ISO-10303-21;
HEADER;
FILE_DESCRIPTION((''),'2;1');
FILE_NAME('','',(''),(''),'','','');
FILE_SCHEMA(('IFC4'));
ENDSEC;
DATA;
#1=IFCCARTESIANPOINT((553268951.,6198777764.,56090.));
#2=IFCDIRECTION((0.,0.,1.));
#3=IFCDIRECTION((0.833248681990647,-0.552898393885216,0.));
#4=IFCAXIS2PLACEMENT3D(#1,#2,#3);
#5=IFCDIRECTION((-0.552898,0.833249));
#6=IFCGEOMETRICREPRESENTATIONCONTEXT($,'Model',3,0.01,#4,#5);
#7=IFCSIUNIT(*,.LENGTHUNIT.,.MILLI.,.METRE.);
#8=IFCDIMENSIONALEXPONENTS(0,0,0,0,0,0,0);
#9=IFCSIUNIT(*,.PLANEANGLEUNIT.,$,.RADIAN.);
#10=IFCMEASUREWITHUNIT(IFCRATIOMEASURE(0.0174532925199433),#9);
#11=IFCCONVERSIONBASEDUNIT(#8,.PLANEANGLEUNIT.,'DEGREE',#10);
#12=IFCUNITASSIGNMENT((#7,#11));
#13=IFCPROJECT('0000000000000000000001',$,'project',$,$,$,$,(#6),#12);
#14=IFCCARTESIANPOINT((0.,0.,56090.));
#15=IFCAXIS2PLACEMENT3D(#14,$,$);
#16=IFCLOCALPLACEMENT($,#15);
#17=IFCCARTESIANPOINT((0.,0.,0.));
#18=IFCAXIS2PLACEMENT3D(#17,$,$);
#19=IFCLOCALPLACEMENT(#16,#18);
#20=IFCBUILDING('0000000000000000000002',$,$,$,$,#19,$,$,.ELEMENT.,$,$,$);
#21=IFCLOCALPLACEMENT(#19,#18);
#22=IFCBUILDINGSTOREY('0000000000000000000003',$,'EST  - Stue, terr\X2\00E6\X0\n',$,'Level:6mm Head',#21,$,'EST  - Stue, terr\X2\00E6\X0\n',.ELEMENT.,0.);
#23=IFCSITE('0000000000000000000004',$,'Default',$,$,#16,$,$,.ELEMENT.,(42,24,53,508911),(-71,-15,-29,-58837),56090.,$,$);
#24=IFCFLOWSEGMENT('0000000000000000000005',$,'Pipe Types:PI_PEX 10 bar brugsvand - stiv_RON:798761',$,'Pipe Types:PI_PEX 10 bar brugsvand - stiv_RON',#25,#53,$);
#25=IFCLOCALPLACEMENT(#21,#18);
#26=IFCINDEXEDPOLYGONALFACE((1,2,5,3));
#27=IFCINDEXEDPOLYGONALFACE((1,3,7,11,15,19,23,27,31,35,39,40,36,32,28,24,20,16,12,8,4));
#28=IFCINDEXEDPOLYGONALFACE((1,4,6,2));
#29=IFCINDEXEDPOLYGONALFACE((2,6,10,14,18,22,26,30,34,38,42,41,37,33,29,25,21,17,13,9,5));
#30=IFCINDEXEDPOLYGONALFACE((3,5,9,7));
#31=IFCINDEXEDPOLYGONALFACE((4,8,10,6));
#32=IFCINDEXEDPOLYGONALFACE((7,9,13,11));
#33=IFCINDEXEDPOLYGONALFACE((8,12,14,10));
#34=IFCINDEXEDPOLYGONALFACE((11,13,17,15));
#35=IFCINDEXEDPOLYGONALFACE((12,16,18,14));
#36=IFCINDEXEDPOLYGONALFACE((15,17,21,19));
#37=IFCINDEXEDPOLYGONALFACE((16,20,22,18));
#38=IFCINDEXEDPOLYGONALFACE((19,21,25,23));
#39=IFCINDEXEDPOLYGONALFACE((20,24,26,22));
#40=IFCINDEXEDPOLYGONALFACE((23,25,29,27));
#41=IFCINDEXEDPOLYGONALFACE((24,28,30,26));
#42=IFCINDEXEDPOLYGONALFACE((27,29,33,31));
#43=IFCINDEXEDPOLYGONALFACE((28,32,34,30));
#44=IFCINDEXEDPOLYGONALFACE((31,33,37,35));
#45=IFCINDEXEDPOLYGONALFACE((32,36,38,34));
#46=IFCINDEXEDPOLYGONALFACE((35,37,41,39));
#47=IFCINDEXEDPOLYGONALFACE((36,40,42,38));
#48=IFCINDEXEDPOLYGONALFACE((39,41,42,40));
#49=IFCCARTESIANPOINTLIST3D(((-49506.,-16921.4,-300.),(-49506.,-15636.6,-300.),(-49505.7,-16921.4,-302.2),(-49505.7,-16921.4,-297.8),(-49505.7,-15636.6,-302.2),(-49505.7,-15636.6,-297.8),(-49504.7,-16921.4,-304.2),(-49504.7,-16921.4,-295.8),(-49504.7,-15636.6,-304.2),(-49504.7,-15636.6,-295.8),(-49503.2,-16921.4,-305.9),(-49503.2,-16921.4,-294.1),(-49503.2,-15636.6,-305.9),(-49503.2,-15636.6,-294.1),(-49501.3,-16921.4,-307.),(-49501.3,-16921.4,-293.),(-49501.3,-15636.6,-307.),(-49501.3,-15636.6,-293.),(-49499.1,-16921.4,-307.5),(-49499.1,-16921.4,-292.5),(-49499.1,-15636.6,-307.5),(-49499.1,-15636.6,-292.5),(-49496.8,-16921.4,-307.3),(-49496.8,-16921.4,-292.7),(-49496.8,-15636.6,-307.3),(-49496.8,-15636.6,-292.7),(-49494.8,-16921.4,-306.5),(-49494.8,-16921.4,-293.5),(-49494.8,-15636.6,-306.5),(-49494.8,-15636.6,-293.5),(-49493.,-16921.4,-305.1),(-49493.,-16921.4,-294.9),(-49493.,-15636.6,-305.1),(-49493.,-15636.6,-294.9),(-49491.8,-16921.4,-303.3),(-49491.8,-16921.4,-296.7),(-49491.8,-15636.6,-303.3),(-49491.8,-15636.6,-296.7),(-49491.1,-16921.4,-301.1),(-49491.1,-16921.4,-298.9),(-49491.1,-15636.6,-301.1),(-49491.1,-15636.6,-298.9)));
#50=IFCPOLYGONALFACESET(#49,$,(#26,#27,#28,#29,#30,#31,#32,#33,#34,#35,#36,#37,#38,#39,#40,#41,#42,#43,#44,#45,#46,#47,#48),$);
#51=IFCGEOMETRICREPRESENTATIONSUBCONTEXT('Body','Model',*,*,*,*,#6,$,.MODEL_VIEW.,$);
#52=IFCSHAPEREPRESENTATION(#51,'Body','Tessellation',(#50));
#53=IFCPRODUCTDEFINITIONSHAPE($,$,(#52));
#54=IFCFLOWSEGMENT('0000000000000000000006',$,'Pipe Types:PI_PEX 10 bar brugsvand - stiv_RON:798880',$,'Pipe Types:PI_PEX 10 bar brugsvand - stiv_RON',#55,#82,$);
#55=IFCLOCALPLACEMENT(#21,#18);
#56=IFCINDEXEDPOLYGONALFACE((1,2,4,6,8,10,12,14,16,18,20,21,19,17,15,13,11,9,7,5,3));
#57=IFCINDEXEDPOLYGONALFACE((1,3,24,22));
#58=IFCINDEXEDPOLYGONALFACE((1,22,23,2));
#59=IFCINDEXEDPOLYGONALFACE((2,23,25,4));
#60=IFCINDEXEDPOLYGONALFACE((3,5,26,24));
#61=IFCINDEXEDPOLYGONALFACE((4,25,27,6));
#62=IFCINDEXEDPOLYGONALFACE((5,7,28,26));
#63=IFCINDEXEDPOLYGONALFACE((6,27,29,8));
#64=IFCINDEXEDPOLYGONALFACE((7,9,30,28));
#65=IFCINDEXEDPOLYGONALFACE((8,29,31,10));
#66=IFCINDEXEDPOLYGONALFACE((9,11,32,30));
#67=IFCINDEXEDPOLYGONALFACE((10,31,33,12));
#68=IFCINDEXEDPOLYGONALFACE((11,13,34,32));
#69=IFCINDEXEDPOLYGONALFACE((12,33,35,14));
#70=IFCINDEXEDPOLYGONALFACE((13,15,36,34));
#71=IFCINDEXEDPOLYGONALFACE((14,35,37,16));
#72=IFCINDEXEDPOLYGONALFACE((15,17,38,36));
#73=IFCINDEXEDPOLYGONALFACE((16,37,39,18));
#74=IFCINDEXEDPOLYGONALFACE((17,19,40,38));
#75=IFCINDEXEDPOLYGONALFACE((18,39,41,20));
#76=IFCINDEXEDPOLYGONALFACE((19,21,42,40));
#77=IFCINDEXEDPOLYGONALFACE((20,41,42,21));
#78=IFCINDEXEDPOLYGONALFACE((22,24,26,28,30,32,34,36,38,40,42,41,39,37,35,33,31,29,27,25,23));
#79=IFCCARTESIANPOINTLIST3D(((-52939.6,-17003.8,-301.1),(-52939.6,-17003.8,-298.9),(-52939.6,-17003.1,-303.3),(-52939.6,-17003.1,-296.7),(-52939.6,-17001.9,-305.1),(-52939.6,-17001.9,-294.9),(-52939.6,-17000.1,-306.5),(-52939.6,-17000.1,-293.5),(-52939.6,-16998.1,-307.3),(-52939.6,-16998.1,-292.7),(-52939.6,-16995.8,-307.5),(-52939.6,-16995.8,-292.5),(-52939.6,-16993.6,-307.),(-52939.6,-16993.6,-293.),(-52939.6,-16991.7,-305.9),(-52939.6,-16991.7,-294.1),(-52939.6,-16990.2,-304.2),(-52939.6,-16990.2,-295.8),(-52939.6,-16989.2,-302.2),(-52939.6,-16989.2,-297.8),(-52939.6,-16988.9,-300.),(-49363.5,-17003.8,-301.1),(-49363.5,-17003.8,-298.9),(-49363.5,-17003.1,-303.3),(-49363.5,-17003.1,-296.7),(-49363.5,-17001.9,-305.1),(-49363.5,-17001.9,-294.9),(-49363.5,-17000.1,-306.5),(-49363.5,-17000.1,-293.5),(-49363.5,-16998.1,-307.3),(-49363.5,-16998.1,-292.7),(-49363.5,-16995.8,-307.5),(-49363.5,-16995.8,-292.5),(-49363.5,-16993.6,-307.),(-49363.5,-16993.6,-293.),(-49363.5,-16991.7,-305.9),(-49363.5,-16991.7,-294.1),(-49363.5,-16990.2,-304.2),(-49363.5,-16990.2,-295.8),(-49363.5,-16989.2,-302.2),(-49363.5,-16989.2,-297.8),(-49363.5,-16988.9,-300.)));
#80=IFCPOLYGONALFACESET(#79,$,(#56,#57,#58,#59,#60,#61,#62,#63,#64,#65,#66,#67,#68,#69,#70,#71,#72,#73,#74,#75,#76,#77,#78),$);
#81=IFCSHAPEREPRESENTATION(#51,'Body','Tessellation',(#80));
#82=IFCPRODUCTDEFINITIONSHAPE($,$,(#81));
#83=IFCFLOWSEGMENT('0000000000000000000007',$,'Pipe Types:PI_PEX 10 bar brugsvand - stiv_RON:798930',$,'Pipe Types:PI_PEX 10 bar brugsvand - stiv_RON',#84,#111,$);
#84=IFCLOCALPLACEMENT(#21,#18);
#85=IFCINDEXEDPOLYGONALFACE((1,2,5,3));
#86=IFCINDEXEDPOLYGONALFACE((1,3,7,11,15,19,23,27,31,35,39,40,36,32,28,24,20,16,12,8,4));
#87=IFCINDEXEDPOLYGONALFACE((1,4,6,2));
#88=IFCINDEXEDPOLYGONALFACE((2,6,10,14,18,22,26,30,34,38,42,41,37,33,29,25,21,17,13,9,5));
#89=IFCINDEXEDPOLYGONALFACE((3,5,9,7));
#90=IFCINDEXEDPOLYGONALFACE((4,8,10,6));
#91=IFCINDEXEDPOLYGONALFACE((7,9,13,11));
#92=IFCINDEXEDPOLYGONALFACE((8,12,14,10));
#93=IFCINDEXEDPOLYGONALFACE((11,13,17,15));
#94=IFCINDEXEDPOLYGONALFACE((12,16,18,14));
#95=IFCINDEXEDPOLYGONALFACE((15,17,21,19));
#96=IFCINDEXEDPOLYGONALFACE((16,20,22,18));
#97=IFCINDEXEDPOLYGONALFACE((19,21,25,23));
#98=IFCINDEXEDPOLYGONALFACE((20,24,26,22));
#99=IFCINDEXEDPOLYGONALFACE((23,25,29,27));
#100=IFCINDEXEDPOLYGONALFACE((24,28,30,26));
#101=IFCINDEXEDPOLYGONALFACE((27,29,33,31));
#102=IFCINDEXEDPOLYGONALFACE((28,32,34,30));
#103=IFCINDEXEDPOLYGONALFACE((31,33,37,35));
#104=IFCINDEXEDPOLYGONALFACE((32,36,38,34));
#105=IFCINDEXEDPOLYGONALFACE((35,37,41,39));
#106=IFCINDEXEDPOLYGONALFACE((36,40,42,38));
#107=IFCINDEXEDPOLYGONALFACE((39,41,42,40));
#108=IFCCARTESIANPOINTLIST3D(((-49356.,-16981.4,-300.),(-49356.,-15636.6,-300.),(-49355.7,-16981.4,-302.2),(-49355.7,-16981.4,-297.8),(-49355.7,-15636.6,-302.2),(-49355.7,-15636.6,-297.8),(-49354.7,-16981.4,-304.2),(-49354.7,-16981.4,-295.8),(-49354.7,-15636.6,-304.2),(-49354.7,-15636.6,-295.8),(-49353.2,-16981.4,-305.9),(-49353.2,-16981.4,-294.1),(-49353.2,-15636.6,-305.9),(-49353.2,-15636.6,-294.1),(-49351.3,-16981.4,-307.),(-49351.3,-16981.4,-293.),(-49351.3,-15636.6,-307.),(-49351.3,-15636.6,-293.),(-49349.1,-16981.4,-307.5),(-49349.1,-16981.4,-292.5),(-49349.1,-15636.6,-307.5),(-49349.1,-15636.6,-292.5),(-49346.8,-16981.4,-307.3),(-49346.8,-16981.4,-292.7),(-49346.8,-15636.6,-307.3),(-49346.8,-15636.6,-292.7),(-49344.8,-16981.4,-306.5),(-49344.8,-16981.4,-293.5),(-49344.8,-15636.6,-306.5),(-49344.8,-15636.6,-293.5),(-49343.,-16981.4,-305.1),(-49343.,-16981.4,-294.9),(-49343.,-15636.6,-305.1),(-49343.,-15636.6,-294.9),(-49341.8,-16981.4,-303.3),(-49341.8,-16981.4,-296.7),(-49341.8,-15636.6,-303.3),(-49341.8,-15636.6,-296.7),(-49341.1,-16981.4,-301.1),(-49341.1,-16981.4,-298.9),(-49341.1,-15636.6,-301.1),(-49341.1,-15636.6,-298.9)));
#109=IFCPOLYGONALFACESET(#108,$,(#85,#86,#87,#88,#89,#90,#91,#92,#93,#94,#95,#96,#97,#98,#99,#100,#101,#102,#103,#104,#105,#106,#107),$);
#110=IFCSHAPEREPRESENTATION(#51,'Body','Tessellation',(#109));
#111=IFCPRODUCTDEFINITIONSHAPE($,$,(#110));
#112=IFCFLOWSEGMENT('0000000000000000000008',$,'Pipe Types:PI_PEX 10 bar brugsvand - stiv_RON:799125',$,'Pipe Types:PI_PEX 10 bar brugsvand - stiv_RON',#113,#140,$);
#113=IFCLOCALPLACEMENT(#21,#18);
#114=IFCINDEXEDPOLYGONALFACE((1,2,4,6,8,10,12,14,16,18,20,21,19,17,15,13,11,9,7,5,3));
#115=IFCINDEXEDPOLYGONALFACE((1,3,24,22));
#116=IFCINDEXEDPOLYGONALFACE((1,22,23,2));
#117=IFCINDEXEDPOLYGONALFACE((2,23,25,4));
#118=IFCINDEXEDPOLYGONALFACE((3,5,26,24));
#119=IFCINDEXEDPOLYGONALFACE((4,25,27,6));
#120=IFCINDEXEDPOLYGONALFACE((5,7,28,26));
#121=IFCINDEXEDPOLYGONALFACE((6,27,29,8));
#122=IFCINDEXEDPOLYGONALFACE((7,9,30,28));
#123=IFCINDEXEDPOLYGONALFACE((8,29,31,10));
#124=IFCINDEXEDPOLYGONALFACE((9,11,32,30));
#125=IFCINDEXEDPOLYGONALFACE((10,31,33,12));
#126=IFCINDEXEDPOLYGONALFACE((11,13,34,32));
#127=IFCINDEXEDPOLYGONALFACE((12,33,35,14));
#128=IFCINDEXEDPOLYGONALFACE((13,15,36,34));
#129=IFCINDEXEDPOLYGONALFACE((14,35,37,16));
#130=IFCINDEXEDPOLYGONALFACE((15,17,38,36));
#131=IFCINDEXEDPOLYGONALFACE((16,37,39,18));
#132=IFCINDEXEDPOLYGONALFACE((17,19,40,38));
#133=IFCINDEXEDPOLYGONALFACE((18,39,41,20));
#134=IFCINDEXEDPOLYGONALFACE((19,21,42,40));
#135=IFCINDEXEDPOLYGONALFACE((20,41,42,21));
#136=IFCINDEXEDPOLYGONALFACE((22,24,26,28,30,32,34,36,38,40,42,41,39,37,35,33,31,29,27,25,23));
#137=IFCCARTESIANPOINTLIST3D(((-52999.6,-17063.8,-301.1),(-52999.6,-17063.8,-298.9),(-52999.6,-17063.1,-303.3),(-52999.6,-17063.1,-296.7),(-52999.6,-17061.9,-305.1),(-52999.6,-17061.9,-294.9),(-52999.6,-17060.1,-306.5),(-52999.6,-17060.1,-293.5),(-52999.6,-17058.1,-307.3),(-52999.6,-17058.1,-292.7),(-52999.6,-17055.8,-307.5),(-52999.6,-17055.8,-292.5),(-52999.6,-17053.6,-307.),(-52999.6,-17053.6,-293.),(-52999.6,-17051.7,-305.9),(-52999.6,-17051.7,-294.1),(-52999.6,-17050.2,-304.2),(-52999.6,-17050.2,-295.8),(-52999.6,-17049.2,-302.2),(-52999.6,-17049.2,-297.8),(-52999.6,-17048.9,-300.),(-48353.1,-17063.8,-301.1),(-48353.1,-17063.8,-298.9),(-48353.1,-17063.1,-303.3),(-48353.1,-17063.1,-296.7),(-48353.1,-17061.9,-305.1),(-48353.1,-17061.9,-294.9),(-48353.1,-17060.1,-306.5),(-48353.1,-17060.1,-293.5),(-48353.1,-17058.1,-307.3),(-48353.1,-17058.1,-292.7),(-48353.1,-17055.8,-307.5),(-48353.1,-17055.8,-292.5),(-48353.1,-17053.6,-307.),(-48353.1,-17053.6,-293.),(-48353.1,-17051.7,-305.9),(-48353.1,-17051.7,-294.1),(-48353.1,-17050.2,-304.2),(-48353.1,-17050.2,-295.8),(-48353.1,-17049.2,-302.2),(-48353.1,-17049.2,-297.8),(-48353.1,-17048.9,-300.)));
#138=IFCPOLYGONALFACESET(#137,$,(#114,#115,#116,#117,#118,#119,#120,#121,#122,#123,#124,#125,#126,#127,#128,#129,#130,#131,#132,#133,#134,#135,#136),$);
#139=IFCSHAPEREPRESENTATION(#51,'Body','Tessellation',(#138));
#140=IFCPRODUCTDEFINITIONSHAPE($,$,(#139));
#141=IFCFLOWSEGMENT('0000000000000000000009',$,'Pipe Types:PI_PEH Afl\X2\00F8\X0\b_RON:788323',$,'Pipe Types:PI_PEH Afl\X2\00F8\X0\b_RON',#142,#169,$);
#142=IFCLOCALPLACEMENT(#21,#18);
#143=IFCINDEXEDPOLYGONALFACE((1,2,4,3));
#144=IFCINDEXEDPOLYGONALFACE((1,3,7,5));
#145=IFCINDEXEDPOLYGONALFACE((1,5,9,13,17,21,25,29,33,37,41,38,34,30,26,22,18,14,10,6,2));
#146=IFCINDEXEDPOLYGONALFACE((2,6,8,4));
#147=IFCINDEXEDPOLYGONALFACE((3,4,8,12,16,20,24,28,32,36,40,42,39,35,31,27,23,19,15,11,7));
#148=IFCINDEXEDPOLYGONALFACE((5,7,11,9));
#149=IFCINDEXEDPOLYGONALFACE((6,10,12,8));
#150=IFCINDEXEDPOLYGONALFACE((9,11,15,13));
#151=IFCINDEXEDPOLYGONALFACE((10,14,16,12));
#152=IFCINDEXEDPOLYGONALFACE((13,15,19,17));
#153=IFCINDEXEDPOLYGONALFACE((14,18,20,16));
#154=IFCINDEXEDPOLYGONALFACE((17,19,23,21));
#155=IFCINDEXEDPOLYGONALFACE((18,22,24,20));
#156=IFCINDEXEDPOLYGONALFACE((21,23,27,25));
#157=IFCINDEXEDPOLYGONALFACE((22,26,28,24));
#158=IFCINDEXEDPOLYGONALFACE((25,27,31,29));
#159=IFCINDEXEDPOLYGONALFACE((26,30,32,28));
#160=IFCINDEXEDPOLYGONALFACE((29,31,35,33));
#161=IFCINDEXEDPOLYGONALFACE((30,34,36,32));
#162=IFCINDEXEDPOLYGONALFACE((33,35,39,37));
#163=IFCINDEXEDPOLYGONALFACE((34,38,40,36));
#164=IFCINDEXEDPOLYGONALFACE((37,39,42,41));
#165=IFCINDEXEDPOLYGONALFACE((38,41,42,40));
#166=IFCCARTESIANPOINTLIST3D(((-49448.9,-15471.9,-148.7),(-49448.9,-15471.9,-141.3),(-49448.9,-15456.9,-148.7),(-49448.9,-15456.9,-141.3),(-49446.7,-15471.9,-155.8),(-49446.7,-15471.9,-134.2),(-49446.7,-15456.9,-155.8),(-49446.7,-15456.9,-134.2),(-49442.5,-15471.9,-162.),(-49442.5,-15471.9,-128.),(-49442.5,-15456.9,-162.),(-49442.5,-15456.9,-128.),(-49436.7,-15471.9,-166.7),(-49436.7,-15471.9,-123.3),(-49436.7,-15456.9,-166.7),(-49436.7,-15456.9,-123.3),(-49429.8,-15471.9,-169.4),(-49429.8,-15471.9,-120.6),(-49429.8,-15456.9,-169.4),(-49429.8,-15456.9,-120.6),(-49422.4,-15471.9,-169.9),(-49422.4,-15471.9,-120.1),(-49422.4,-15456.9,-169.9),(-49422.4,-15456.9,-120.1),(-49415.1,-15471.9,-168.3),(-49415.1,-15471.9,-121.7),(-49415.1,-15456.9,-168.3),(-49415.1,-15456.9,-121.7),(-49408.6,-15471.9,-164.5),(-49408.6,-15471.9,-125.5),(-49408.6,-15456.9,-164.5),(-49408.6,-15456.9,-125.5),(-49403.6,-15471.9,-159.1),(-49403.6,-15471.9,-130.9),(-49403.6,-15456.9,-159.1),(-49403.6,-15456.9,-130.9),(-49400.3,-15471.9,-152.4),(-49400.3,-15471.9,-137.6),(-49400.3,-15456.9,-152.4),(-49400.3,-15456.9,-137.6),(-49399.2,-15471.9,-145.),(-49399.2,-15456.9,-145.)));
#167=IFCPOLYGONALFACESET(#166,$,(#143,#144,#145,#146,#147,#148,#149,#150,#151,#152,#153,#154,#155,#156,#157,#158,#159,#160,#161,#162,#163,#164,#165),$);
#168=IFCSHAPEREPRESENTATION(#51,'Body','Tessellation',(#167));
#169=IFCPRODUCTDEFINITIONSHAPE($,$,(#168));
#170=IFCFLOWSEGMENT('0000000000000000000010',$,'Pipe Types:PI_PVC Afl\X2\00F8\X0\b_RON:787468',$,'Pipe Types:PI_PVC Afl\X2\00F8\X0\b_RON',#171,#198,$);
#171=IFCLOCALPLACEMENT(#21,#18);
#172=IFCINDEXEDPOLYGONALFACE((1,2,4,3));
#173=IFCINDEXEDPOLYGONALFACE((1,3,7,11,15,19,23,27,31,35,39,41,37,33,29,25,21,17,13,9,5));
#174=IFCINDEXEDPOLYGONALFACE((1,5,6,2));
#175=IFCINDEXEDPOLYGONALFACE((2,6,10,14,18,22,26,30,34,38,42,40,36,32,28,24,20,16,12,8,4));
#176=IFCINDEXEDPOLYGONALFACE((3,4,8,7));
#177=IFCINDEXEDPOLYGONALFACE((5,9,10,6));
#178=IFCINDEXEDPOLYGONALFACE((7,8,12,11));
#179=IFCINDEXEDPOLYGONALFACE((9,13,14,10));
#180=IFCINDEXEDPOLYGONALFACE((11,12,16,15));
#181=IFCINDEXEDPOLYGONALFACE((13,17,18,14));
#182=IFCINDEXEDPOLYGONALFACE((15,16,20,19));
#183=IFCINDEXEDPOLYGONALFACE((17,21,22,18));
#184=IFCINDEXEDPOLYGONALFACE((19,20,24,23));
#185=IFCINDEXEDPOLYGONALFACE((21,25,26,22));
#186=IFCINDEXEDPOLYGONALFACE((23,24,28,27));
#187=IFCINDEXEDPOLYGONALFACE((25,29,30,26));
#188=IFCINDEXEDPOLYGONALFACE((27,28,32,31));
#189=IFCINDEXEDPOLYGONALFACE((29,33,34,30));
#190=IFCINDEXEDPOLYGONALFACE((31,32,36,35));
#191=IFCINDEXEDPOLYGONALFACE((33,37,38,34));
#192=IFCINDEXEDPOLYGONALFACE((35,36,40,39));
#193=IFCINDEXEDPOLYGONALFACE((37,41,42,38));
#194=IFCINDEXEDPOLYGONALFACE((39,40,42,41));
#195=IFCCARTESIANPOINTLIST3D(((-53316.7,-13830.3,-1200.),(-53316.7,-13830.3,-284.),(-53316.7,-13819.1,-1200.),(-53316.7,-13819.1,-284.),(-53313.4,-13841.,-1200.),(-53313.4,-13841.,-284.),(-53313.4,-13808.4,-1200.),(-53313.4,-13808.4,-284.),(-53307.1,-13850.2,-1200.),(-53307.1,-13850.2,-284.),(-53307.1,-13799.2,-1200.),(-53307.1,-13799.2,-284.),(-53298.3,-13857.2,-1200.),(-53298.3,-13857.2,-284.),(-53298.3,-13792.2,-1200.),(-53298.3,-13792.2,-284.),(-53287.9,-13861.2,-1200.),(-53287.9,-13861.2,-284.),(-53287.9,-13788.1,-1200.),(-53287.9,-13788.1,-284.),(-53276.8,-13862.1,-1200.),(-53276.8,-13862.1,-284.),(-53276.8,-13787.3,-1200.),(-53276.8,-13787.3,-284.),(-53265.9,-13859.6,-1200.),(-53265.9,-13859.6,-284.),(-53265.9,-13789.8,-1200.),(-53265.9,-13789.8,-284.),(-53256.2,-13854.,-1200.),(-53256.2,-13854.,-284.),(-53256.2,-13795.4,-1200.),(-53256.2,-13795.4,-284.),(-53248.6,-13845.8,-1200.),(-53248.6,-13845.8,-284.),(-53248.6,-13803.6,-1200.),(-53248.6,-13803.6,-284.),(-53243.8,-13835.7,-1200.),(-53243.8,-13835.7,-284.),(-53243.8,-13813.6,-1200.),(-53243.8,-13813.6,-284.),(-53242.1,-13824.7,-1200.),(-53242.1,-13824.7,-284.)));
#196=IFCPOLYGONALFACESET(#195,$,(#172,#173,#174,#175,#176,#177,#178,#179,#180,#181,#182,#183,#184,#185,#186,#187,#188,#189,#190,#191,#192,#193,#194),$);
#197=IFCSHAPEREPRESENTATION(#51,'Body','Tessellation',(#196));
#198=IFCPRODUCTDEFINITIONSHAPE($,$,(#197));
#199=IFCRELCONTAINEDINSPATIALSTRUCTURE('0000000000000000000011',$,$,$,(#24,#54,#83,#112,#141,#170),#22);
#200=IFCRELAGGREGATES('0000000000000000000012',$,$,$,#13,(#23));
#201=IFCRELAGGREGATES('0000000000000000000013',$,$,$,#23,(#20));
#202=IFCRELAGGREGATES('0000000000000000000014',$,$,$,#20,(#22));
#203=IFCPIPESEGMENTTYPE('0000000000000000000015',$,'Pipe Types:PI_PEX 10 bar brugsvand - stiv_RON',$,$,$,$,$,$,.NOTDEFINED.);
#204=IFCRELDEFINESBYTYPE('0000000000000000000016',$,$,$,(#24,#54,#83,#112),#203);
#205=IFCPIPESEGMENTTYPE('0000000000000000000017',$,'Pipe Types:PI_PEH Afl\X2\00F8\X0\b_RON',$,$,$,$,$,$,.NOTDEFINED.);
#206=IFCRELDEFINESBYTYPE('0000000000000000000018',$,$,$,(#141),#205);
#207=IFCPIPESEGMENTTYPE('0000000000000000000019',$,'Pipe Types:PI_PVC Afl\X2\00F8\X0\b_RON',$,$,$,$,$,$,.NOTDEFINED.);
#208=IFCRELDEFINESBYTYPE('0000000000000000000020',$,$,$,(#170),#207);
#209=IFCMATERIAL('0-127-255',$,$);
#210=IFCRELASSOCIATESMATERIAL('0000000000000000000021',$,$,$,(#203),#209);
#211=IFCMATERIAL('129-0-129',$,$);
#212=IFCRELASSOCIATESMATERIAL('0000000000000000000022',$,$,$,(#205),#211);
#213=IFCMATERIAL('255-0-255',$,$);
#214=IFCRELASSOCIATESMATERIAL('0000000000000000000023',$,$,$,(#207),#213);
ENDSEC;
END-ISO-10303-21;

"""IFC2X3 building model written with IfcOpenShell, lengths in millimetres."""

from ifc_helpers import new_model, entity, si_unit, converted_unit, direction, frame, frame_2d, origin, origin_2d_with_axis, place, context, subcontext, project, spatial, circle, extrude, material, type_object, element, save


model = new_model("IFC2X3")

# Units and contexts
model_context = context("Model", 3, precision=0.01, world=frame((553268951.0, 6198777764.0, 56090.0), z_axis=(0.0, 0.0, 1.0), x_axis=(0.833248681990647, -0.552898393885216, 0.0)), true_north=direction((-0.552898, 0.833249)))
body_context = subcontext(model_context, "Body", "Model", "MODEL_VIEW")
ifc_project = project(units=[si_unit("LENGTHUNIT", "METRE", prefix="MILLI"), converted_unit("PLANEANGLEUNIT", "DEGREE", entity("IfcRatioMeasure", 0.0174532925199433), si_unit("PLANEANGLEUNIT", "RADIAN"), dimensions=[0, 0, 0, 0, 0, 0, 0])], contexts=[model_context])

# Site, building, storey
site_placement = place(None, frame((0.0, 0.0, 56090.0)))
site = spatial("IfcSite", under=ifc_project, at=site_placement, Name="Default", CompositionType="ELEMENT", RefLatitude=(42, 24, 53, 508911), RefLongitude=(-71, -15, -29, -58837), RefElevation=56090.0)
building_placement = place(site_placement, origin())
building = spatial("IfcBuilding", under=site, at=building_placement, CompositionType="ELEMENT")
storey_placement = place(building_placement, frame((0.0, 0.0, 0.0)))
storey = spatial("IfcBuildingStorey", under=building, at=storey_placement, Name="EST  - Stue, terræn", ObjectType="Level:6mm Head", LongName="EST  - Stue, terræn", CompositionType="ELEMENT", Elevation=0.0)

# Flow segments
ifc_material_1 = material(Name="0-127-255")
pipe_segment_type_1 = type_object("IfcPipeSegmentType", Name="Pipe Types:PI_PEX 10 bar brugsvand - stiv_RON", PredefinedType="NOTDEFINED", material=ifc_material_1)
flow_segment_1_placement = place(storey_placement, origin())
element("IfcFlowSegment", 1, at=flow_segment_1_placement, inside=storey, type_object=pipe_segment_type_1, Name="Pipe Types:PI_PEX 10 bar brugsvand - stiv_RON:798761", ObjectType="Pipe Types:PI_PEX 10 bar brugsvand - stiv_RON", context=body_context, shape_type="SweptSolid", body=[
    extrude(circle(Radius=7.5, at=frame_2d((0.0, 0.0), x_axis=(1.0, 0.0))), frame((-49498.5, -16921.4, -300.0), z_axis=(0.0, 1.0, 0.0), x_axis=(-1.0, 0.0, 0.0)), (0.0, 0.0, 1.0), 1284.8),
])
flow_segment_2_placement = place(storey_placement, origin())
element("IfcFlowSegment", 2, at=flow_segment_2_placement, inside=storey, type_object=pipe_segment_type_1, Name="Pipe Types:PI_PEX 10 bar brugsvand - stiv_RON:798880", ObjectType="Pipe Types:PI_PEX 10 bar brugsvand - stiv_RON", context=body_context, shape_type="SweptSolid", body=[
    extrude(circle(Radius=7.5, at=frame_2d((0.0, 0.0), x_axis=(1.0, 0.0))), frame((-52939.6, -16996.4, -300.0), z_axis=(1.0, 0.0, 0.0), x_axis=(0.0, 1.0, 0.0)), (0.0, 0.0, 1.0), 3576.0),
])
flow_segment_3_placement = place(storey_placement, origin())
element("IfcFlowSegment", 3, at=flow_segment_3_placement, inside=storey, type_object=pipe_segment_type_1, Name="Pipe Types:PI_PEX 10 bar brugsvand - stiv_RON:798930", ObjectType="Pipe Types:PI_PEX 10 bar brugsvand - stiv_RON", context=body_context, shape_type="SweptSolid", body=[
    extrude(circle(Radius=7.5, at=origin_2d_with_axis()), frame((-49348.5, -16981.4, -300.0), z_axis=(0.0, 1.0, 0.0), x_axis=(-1.0, 0.0, 0.0)), (0.0, 0.0, 1.0), 1344.8),
])
flow_segment_4_placement = place(storey_placement, origin())
element("IfcFlowSegment", 4, at=flow_segment_4_placement, inside=storey, type_object=pipe_segment_type_1, Name="Pipe Types:PI_PEX 10 bar brugsvand - stiv_RON:799125", ObjectType="Pipe Types:PI_PEX 10 bar brugsvand - stiv_RON", context=body_context, shape_type="SweptSolid", body=[
    extrude(circle(Radius=7.5, at=frame_2d((0.0, 0.0), x_axis=(1.0, 0.0))), frame((-52999.6, -17056.4, -300.0), z_axis=(1.0, 0.0, 0.0), x_axis=(0.0, 1.0, 0.0)), (0.0, 0.0, 1.0), 4646.5),
])
ifc_material_2 = material(Name="129-0-129")
pipe_segment_type_2 = type_object("IfcPipeSegmentType", Name="Pipe Types:PI_PEH Afløb_RON", PredefinedType="NOTDEFINED", material=ifc_material_2)
flow_segment_5_placement = place(storey_placement, origin())
element("IfcFlowSegment", 5, at=flow_segment_5_placement, inside=storey, type_object=pipe_segment_type_2, Name="Pipe Types:PI_PEH Afløb_RON:788323", ObjectType="Pipe Types:PI_PEH Afløb_RON", context=body_context, shape_type="SweptSolid", body=[
    extrude(circle(Radius=25.0, at=frame_2d((0.0, 0.0), x_axis=(1.0, 0.0))), frame((-49424.2, -15471.9, -145.0), z_axis=(0.0, 1.0, 0.0), x_axis=(1.0, 0.0, 0.0)), (0.0, 0.0, 1.0), 15.0),
])
ifc_material_3 = material(Name="255-0-255")
pipe_segment_type_3 = type_object("IfcPipeSegmentType", Name="Pipe Types:PI_PVC Afløb_RON", PredefinedType="NOTDEFINED", material=ifc_material_3)
flow_segment_6_placement = place(storey_placement, origin())
element("IfcFlowSegment", 6, at=flow_segment_6_placement, inside=storey, type_object=pipe_segment_type_3, Name="Pipe Types:PI_PVC Afløb_RON:787468", ObjectType="Pipe Types:PI_PVC Afløb_RON", context=body_context, shape_type="SweptSolid", body=[
    extrude(circle(Radius=37.5, at=frame_2d((0.0, 0.0), x_axis=(1.0, 0.0))), frame((-53279.6, -13824.7, -1200.0)), (0.0, 0.0, 1.0), 916.0),
])

save(model, "model.ifc")
